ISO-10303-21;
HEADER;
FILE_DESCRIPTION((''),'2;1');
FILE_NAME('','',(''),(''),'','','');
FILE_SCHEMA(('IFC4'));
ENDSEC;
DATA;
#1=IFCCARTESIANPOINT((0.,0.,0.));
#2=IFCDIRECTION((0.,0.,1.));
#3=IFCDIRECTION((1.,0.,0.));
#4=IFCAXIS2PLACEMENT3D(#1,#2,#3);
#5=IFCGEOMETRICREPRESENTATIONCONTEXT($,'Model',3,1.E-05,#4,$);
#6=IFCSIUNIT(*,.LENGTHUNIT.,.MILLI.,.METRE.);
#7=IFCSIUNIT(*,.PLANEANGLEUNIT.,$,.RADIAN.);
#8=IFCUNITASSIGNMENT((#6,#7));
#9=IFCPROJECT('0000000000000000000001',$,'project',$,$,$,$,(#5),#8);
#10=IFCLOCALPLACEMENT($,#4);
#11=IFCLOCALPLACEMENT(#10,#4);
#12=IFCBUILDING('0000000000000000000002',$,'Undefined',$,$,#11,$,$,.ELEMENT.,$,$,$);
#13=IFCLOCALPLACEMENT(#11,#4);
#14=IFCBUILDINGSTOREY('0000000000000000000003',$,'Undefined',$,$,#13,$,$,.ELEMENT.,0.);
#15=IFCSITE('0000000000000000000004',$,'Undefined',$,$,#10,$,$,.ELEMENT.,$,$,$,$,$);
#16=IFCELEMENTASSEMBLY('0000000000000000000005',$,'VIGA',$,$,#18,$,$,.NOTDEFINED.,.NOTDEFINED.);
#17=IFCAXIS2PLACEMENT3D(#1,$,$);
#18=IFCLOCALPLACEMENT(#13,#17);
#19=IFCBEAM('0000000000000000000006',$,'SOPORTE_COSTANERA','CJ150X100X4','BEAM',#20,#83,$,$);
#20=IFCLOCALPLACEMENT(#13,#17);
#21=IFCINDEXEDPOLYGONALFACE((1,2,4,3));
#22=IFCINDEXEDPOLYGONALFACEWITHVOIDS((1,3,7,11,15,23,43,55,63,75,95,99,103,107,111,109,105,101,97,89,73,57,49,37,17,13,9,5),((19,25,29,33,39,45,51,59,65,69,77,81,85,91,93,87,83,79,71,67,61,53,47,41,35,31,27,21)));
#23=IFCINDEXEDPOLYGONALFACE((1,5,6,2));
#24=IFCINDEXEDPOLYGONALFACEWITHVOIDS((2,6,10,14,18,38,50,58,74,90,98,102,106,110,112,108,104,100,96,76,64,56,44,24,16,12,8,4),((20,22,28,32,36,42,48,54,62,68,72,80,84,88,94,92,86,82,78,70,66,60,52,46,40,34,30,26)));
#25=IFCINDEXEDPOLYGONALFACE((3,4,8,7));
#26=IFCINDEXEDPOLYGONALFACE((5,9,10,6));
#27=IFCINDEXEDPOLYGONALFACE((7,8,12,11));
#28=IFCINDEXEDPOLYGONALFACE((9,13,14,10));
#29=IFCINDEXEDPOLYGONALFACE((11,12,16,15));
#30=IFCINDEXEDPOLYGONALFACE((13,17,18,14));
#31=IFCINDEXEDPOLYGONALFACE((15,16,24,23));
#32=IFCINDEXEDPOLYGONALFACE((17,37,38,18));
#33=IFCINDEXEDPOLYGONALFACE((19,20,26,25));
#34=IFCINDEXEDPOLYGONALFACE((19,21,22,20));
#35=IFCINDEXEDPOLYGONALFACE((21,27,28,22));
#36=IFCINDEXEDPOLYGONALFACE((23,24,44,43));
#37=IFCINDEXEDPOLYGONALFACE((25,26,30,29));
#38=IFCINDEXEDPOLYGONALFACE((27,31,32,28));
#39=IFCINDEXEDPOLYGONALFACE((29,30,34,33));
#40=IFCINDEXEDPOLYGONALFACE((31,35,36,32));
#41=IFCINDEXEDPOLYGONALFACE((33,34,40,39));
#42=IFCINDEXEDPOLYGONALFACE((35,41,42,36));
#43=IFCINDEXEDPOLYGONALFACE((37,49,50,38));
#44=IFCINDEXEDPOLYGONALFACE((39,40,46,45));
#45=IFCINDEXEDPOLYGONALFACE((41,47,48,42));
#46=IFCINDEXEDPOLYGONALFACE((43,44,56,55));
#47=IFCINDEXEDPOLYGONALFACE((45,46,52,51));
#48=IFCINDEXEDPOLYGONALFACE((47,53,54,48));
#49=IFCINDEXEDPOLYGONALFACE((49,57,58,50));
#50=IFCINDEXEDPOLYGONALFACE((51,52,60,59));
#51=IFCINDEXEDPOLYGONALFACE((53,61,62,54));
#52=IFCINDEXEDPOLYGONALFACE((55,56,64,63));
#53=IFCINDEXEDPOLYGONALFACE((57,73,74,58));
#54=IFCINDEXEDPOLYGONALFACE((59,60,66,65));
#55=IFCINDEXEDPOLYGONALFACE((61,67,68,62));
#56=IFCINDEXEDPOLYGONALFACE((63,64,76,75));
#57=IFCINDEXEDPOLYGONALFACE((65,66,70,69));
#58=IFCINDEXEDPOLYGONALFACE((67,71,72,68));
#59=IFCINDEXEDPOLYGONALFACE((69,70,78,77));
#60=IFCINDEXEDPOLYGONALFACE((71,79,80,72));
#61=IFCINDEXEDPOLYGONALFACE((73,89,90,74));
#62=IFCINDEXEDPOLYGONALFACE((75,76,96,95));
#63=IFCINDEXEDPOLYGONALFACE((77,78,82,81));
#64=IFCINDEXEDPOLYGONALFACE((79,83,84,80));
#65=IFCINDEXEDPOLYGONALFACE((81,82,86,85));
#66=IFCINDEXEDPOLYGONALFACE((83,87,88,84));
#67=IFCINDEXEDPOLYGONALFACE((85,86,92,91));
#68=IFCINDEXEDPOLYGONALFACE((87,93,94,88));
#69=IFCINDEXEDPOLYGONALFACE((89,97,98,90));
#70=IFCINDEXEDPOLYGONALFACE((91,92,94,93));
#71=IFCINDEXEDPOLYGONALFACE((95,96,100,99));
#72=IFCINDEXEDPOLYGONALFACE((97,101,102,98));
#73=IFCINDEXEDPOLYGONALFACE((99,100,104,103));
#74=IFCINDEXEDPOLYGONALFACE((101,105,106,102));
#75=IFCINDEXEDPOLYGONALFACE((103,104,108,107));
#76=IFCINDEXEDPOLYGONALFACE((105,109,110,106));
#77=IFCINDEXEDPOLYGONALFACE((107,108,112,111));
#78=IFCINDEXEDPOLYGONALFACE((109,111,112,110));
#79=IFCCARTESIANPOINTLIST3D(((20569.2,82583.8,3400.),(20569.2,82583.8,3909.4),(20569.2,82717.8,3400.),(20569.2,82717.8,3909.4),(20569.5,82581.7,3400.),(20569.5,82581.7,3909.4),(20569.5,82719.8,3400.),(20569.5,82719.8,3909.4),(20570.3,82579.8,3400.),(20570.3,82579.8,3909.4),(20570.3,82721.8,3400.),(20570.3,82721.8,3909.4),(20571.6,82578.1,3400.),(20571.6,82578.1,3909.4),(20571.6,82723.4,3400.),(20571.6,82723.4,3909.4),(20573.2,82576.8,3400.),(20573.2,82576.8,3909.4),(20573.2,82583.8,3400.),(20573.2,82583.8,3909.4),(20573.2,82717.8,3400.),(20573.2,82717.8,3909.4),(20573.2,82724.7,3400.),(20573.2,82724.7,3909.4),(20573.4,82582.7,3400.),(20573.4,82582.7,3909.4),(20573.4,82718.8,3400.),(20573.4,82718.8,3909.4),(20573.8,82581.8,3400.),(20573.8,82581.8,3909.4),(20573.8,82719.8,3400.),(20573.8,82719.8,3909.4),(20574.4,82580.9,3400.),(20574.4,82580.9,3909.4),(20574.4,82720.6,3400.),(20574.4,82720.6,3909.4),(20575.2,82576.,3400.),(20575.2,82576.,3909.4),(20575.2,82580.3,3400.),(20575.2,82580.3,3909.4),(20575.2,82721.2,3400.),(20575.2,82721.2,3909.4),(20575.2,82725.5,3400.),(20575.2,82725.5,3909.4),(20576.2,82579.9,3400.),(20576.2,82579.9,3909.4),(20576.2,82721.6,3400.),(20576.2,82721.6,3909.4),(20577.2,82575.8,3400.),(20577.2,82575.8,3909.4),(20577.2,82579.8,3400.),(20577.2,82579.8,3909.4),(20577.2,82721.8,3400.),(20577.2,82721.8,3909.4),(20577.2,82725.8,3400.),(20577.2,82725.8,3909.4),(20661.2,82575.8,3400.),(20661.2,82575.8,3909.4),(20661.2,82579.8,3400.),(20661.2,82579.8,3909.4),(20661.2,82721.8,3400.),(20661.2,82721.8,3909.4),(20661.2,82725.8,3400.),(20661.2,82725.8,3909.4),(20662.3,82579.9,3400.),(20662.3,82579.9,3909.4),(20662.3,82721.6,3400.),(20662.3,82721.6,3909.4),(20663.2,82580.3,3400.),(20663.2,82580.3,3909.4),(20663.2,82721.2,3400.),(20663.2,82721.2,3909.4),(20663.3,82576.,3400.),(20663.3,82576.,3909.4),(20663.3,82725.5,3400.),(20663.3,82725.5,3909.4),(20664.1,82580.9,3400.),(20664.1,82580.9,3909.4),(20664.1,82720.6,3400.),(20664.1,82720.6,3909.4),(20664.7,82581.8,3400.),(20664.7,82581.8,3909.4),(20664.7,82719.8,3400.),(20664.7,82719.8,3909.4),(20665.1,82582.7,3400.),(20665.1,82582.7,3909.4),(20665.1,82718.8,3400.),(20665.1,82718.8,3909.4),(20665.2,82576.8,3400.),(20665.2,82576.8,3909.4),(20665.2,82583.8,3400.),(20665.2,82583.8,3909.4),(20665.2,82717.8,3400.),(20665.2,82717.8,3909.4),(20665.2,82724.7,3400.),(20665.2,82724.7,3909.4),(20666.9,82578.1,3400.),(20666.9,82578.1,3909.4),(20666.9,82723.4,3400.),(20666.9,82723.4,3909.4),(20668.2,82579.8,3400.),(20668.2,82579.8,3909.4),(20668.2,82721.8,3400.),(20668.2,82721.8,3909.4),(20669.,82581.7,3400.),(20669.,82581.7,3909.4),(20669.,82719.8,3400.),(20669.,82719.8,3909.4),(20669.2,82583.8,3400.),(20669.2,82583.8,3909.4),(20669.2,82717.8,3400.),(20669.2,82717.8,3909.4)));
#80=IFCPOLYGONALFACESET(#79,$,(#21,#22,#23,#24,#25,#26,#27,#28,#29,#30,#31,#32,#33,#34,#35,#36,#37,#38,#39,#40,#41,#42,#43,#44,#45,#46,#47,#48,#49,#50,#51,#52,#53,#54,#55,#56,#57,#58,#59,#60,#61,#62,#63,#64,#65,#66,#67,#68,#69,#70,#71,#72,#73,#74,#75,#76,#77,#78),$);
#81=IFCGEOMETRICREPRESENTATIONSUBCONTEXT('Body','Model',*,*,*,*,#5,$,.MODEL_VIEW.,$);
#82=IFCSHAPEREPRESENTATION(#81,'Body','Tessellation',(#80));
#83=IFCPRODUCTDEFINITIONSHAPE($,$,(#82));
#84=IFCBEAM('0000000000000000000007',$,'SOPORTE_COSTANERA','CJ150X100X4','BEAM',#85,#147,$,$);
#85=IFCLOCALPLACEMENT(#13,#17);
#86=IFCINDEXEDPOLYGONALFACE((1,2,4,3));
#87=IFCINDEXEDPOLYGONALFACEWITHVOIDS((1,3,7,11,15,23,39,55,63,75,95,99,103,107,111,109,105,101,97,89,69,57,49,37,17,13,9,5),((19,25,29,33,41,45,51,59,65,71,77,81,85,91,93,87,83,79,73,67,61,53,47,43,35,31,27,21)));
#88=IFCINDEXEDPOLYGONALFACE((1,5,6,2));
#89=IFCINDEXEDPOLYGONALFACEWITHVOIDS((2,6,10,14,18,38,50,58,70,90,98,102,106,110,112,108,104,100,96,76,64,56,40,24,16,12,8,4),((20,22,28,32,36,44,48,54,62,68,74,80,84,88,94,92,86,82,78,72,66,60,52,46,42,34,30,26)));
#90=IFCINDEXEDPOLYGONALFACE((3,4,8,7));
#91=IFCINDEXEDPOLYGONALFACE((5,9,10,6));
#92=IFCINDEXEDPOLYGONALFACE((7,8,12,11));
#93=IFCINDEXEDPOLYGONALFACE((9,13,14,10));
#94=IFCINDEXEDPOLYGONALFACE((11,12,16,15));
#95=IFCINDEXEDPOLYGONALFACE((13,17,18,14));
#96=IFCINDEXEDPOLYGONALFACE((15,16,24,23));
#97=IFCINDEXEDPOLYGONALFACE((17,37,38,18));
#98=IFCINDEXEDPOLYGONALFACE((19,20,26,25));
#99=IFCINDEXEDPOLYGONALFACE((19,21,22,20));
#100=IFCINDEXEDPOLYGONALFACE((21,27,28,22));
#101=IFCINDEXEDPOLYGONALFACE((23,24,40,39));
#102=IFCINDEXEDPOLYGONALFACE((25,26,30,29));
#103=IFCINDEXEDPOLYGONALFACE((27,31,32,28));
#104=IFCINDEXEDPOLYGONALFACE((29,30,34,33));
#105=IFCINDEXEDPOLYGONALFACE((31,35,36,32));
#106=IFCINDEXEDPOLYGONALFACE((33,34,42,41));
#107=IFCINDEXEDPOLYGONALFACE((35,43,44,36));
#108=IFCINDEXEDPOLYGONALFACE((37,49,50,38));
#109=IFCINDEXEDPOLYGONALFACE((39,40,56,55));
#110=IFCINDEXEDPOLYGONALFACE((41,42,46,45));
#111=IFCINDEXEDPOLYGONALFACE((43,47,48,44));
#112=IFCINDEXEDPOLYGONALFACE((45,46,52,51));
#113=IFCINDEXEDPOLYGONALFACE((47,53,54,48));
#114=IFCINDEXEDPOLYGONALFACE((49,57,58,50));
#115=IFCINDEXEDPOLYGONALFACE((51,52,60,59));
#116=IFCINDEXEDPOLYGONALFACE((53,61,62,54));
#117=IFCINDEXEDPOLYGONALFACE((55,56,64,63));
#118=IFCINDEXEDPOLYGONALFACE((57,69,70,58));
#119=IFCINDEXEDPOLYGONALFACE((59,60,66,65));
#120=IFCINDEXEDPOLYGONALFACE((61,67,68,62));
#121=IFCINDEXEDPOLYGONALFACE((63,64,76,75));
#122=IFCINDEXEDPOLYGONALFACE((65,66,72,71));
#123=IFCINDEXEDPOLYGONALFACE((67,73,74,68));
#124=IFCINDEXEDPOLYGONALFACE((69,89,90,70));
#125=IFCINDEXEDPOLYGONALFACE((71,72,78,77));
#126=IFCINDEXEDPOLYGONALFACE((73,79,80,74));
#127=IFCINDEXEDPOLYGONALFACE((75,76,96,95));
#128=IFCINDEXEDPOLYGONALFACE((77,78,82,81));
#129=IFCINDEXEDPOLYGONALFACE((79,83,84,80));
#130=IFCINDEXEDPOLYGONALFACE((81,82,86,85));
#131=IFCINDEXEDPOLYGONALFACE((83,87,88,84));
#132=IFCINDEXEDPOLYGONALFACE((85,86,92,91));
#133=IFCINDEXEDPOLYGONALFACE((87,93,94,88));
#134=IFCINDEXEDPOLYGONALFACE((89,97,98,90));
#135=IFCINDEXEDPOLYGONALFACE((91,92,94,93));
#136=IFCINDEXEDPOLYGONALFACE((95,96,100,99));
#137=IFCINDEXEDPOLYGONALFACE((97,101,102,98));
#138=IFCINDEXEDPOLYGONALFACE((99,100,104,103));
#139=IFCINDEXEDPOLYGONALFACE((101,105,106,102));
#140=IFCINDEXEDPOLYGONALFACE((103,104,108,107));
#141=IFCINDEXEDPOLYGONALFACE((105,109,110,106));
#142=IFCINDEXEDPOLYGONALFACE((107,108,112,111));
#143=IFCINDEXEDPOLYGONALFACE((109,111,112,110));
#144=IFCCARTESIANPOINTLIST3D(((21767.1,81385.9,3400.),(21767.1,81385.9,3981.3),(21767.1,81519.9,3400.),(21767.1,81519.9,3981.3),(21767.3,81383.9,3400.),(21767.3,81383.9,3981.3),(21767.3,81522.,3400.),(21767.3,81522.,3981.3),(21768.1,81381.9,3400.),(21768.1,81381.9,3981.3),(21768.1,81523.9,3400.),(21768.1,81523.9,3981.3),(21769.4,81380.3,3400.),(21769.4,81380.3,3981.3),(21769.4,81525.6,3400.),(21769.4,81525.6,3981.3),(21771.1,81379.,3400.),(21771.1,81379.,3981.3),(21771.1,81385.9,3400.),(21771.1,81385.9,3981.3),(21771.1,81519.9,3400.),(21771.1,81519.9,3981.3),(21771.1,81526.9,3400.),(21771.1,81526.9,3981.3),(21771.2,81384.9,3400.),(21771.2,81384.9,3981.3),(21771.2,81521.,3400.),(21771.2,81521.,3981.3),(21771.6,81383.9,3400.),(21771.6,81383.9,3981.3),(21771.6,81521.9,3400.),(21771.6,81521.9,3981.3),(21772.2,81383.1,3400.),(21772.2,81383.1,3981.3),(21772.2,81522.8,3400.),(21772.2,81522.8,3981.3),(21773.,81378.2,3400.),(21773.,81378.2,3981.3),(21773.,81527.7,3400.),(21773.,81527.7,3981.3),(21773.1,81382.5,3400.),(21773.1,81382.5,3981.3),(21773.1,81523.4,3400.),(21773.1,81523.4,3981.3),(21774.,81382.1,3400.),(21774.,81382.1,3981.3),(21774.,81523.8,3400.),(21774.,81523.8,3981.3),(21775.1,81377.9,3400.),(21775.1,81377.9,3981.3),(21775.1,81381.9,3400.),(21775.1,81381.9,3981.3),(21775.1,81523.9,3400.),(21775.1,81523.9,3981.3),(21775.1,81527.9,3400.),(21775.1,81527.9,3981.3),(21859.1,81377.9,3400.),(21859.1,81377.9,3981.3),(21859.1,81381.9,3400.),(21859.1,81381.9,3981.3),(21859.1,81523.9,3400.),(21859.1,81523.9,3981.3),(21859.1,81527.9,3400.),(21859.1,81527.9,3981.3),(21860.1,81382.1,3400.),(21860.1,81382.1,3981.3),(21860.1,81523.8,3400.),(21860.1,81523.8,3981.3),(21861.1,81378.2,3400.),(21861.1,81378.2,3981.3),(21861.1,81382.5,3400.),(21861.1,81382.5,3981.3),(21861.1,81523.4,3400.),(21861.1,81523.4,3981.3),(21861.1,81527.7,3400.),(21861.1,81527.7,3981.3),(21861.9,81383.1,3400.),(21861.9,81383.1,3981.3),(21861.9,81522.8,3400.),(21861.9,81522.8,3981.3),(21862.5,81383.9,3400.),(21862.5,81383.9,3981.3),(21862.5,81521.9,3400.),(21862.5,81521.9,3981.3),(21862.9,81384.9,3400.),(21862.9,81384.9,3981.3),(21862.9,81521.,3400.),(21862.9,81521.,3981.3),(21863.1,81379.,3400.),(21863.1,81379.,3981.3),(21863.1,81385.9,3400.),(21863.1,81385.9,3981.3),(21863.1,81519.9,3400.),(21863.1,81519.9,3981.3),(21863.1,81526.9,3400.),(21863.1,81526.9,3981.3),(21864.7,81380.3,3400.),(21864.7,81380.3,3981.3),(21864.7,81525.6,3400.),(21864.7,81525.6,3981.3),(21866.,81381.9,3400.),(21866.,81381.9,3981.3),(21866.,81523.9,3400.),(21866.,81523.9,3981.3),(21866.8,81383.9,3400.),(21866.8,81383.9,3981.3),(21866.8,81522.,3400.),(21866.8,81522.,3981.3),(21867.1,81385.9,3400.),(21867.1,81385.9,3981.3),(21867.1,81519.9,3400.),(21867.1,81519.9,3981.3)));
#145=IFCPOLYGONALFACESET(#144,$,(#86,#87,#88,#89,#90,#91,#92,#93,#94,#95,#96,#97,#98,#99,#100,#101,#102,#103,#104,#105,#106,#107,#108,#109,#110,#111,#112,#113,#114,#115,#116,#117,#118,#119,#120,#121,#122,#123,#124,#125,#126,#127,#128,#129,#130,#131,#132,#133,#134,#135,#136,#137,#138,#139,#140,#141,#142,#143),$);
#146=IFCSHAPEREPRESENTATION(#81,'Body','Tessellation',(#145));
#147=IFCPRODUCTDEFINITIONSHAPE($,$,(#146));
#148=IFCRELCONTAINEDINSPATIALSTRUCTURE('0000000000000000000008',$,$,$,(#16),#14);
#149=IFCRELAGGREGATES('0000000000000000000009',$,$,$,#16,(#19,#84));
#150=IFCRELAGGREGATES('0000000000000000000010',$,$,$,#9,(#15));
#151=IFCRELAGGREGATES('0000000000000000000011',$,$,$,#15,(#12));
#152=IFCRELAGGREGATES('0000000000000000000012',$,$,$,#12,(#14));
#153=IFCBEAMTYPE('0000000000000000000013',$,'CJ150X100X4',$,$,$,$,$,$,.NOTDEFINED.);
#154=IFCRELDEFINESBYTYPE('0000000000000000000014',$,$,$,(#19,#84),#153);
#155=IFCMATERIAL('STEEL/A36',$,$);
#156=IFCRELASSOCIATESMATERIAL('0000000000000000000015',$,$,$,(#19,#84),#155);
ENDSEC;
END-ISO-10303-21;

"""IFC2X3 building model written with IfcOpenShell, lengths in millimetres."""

from ifc_helpers import new_model, si_unit, frame, origin_with_axes, origin_2d_with_axis, place, context, subcontext, project, spatial, hollow_rectangle, extrude, material, type_object, element, aggregate, save


model = new_model("IFC2X3")

# Units and contexts
model_context = context("Model", 3, precision=1e-05, world=origin_with_axes())
body_context = subcontext(model_context, "Body", "Model", "MODEL_VIEW")
ifc_project = project(units=[si_unit("LENGTHUNIT", "METRE", prefix="MILLI"), si_unit("PLANEANGLEUNIT", "RADIAN")], contexts=[model_context])

# Site, building, storey
site_placement = place(None, origin_with_axes())
site = spatial("IfcSite", under=ifc_project, at=site_placement, Name="Undefined", CompositionType="ELEMENT")
building_placement = place(site_placement, origin_with_axes())
building = spatial("IfcBuilding", under=site, at=building_placement, Name="Undefined", CompositionType="ELEMENT")
storey_placement = place(building_placement, origin_with_axes())
storey = spatial("IfcBuildingStorey", under=building, at=storey_placement, Name="Undefined", CompositionType="ELEMENT", Elevation=0.0)

# Shared definitions
ifc_material_1 = material(Name="STEEL/A36")

# Element assembly, beams
assembly_1_placement = place(storey_placement, origin_with_axes())
assembly_1 = element("IfcElementAssembly", 1, at=assembly_1_placement, inside=storey, Name="VIGA", AssemblyPlace="NOTDEFINED", PredefinedType="NOTDEFINED")
beam_type_1 = type_object("IfcBeamType", Name="CJ150X100X4", PredefinedType="NOTDEFINED")
beam_1_placement = place(assembly_1_placement, frame((20619.2, 82650.8, 3909.4), z_axis=(0.0, 1.0, 0.0), x_axis=(0.0, 0.0, -1.0)))
beam_1 = element("IfcBeam", 2, at=beam_1_placement, type_object=beam_type_1, material=ifc_material_1, Name="SOPORTE_COSTANERA", Description="CJ150X100X4", ObjectType="BEAM", context=body_context, shape_type="SweptSolid", body=[
    extrude(hollow_rectangle(XDim=100.0, YDim=150.0, WallThickness=4.0, InnerFilletRadius=4.0, OuterFilletRadius=8.0, at=origin_2d_with_axis()), frame((509.4, 0.0, 0.0), z_axis=(-1.0, 0.0, 0.0), x_axis=(0.0, -1.0, 0.0)), (0.0, 0.0, 1.0), 509.4),
])
beam_2_placement = place(assembly_1_placement, frame((21817.1, 81452.9, 3981.3), z_axis=(0.0, 1.0, 0.0), x_axis=(0.0, 0.0, -1.0)))
beam_2 = element("IfcBeam", 3, at=beam_2_placement, type_object=beam_type_1, material=ifc_material_1, Name="SOPORTE_COSTANERA", Description="CJ150X100X4", ObjectType="BEAM", context=body_context, shape_type="SweptSolid", body=[
    extrude(hollow_rectangle(XDim=100.0, YDim=150.0, WallThickness=4.0, InnerFilletRadius=4.0, OuterFilletRadius=8.0, at=origin_2d_with_axis()), frame((581.3, 0.0, 0.0), z_axis=(-1.0, 0.0, 0.0), x_axis=(0.0, -1.0, 0.0)), (0.0, 0.0, 1.0), 581.3),
])

aggregate(assembly_1, [beam_1, beam_2])

save(model, "model.ifc")
